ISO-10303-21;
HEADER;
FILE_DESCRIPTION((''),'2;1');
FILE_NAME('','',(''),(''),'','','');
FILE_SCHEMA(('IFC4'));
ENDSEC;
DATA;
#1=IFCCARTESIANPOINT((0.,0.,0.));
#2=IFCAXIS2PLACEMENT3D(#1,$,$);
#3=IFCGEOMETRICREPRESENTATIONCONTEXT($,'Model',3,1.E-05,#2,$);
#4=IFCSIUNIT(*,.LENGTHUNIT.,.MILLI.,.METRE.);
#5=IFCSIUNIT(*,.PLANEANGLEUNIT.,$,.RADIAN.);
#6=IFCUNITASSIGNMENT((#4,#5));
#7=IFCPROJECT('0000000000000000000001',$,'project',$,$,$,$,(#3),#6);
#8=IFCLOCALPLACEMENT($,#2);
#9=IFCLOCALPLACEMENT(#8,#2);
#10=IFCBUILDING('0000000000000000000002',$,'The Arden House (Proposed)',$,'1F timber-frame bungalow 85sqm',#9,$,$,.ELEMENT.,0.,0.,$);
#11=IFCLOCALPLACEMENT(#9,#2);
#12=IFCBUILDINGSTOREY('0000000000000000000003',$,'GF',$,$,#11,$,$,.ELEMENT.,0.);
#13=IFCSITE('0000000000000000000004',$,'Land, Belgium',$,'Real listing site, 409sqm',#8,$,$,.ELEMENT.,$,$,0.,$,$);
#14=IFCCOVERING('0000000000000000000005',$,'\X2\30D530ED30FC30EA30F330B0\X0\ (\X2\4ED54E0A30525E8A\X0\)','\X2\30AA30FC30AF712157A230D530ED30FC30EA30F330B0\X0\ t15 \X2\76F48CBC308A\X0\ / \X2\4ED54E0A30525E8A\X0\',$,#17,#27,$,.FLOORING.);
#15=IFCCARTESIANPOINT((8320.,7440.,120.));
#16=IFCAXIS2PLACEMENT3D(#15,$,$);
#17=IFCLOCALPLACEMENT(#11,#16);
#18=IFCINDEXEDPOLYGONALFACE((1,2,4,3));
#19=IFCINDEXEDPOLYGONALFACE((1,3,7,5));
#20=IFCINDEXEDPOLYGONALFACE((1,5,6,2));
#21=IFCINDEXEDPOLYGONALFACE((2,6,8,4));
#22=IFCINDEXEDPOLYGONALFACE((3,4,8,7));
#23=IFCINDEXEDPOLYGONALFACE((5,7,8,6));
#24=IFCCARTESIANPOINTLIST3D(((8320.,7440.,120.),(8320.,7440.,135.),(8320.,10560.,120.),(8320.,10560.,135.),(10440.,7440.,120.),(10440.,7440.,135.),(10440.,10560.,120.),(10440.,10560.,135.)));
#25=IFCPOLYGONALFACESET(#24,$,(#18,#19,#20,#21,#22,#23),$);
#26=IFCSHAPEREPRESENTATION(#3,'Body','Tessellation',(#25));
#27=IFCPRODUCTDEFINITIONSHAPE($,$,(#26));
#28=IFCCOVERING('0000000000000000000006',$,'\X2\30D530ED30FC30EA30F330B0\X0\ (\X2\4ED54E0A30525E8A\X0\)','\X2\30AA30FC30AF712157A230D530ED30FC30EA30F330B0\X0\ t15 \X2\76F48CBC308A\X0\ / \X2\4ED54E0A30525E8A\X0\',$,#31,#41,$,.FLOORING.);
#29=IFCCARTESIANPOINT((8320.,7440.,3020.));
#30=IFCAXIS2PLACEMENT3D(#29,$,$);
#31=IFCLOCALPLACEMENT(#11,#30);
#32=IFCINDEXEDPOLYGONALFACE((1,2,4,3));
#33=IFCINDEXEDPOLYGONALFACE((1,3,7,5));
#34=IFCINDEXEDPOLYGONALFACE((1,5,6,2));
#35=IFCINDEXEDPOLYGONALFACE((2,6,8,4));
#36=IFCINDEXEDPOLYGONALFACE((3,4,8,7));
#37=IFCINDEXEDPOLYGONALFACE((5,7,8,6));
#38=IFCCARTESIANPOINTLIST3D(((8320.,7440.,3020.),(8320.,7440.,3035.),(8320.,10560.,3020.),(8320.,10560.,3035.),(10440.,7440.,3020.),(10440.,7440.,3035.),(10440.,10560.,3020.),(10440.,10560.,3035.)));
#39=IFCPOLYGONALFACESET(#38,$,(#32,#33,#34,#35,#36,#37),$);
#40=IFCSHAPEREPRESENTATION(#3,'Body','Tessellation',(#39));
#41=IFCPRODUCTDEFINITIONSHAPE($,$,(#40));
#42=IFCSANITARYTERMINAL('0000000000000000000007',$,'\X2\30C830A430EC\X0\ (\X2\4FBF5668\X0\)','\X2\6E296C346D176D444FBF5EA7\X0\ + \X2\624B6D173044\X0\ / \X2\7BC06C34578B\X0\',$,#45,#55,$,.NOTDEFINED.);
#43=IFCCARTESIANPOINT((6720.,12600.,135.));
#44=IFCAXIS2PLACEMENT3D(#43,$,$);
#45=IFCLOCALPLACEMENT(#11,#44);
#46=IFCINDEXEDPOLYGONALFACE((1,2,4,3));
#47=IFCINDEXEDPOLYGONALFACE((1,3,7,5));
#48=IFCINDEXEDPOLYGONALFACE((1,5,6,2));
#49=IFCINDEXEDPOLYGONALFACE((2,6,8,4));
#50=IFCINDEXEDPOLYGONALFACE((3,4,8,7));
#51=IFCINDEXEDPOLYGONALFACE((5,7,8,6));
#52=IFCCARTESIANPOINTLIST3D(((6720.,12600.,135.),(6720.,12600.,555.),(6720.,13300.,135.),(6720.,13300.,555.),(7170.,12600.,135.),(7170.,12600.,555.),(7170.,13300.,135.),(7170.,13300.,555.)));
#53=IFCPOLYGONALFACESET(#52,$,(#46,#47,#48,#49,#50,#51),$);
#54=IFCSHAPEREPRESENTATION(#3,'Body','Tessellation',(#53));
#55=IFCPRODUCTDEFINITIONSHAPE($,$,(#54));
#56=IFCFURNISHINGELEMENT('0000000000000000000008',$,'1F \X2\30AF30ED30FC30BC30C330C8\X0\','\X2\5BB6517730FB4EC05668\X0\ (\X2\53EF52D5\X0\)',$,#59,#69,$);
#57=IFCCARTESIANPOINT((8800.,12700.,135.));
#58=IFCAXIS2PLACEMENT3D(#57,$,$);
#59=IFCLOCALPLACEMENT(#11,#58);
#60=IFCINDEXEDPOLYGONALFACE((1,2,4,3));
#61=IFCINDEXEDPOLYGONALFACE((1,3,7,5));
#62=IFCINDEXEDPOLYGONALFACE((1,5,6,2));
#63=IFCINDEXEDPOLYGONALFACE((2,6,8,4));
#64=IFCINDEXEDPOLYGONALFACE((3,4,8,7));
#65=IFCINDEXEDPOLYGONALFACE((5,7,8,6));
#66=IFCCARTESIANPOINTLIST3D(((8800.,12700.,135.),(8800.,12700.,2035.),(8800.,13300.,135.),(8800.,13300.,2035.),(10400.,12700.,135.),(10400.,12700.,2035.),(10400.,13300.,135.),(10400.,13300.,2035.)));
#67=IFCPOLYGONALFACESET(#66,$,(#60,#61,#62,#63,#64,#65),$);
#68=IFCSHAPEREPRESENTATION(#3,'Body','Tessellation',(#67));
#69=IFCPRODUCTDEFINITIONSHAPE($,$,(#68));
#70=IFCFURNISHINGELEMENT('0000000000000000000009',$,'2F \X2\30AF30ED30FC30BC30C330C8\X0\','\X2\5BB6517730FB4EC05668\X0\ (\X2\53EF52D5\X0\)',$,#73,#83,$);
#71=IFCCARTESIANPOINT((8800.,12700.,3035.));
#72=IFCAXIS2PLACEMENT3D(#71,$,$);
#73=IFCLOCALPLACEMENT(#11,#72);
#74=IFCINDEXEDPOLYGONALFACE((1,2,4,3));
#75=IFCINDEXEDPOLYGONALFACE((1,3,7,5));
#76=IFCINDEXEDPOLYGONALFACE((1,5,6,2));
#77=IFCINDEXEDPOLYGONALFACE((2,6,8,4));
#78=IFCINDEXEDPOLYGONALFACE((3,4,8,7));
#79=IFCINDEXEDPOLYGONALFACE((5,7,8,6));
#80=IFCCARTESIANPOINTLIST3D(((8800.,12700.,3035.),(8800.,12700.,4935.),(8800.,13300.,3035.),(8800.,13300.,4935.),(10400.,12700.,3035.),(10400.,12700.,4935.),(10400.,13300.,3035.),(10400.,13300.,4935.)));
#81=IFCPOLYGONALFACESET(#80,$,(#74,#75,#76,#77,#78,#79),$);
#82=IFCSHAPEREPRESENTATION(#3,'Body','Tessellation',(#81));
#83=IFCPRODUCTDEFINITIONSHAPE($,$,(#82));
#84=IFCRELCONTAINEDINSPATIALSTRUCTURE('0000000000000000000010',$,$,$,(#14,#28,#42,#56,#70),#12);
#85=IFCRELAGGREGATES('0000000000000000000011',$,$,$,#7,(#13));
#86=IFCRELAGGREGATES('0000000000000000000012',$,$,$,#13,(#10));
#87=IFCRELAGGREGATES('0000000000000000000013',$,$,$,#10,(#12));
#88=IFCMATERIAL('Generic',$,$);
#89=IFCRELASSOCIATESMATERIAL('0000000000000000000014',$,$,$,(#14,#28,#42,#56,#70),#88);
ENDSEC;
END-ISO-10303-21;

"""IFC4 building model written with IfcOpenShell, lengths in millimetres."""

from ifc_helpers import new_model, si_unit, frame, frame_2d, origin, place, context, project, spatial, rectangle, extrude, material, element, save


model = new_model("IFC4")

# Units and contexts
model_context = context("Model", 3, precision=1e-05, world=origin())
ifc_project = project(units=[si_unit("LENGTHUNIT", "METRE", prefix="MILLI"), si_unit("PLANEANGLEUNIT", "RADIAN")], contexts=[model_context])

# Site, building, storey
site_placement = place(None, origin())
site = spatial("IfcSite", under=ifc_project, at=site_placement, Name="Land, Belgium", ObjectType="Real listing site, 409sqm", CompositionType="ELEMENT", RefElevation=0.0)
building_placement = place(site_placement, origin())
building = spatial("IfcBuilding", under=site, at=building_placement, Name="The Arden House (Proposed)", ObjectType="1F timber-frame bungalow 85sqm", CompositionType="ELEMENT", ElevationOfRefHeight=0.0, ElevationOfTerrain=0.0)
storey_placement = place(building_placement, origin())
storey = spatial("IfcBuildingStorey", under=building, at=storey_placement, Name="GF", CompositionType="ELEMENT", Elevation=0.0)

# Shared definitions
ifc_material_1 = material(Name="Generic")

# Coverings
covering_1_placement = place(storey_placement, frame((8320.0, 7440.0, 120.0)))
element("IfcCovering", 1, at=covering_1_placement, inside=storey, material=ifc_material_1, Name="フローリング (仕上げ床)", Description="オーク無垢フローリング t15 直貼り / 仕上げ床", PredefinedType="FLOORING", context=model_context, shape_type="SweptSolid", body=[
    extrude(rectangle(XDim=2120.0, YDim=3120.0, at=frame_2d((1060.0, 1560.0))), frame((8320.0, 7440.0, 120.0)), (0.0, 0.0, 1.0), 15.0),
])
covering_2_placement = place(storey_placement, frame((8320.0, 7440.0, 3020.0)))
element("IfcCovering", 2, at=covering_2_placement, inside=storey, material=ifc_material_1, Name="フローリング (仕上げ床)", Description="オーク無垢フローリング t15 直貼り / 仕上げ床", PredefinedType="FLOORING", context=model_context, shape_type="SweptSolid", body=[
    extrude(rectangle(XDim=2120.0, YDim=3120.0, at=frame_2d((1060.0, 1560.0))), frame((8320.0, 7440.0, 3020.0)), (0.0, 0.0, 1.0), 15.0),
])

# Sanitary terminal
sanitary_terminal_placement = place(storey_placement, frame((6720.0, 12600.0, 135.0)))
element("IfcSanitaryTerminal", 3, at=sanitary_terminal_placement, inside=storey, material=ifc_material_1, Name="トイレ (便器)", Description="温水洗浄便座 + 手洗い / 節水型", PredefinedType="NOTDEFINED", context=model_context, shape_type="SweptSolid", body=[
    extrude(rectangle(XDim=450.0, YDim=700.0, at=frame_2d((225.0, 350.0))), frame((6720.0, 12600.0, 135.0)), (0.0, 0.0, 1.0), 420.0),
])

# Furnishing elements
furnishing_1_placement = place(storey_placement, frame((8800.0, 12700.0, 135.0)))
element("IfcFurnishingElement", 4, at=furnishing_1_placement, inside=storey, material=ifc_material_1, Name="1F クローゼット", Description="家具・什器 (可動)", context=model_context, shape_type="SweptSolid", body=[
    extrude(rectangle(XDim=1600.0, YDim=600.0, at=frame_2d((800.0, 300.0))), frame((8800.0, 12700.0, 135.0)), (0.0, 0.0, 1.0), 1900.0),
])
furnishing_2_placement = place(storey_placement, frame((8800.0, 12700.0, 3035.0)))
element("IfcFurnishingElement", 5, at=furnishing_2_placement, inside=storey, material=ifc_material_1, Name="2F クローゼット", Description="家具・什器 (可動)", context=model_context, shape_type="SweptSolid", body=[
    extrude(rectangle(XDim=1600.0, YDim=600.0, at=frame_2d((800.0, 300.0))), frame((8800.0, 12700.0, 3035.0)), (0.0, 0.0, 1.0), 1900.0),
])

save(model, "model.ifc")
